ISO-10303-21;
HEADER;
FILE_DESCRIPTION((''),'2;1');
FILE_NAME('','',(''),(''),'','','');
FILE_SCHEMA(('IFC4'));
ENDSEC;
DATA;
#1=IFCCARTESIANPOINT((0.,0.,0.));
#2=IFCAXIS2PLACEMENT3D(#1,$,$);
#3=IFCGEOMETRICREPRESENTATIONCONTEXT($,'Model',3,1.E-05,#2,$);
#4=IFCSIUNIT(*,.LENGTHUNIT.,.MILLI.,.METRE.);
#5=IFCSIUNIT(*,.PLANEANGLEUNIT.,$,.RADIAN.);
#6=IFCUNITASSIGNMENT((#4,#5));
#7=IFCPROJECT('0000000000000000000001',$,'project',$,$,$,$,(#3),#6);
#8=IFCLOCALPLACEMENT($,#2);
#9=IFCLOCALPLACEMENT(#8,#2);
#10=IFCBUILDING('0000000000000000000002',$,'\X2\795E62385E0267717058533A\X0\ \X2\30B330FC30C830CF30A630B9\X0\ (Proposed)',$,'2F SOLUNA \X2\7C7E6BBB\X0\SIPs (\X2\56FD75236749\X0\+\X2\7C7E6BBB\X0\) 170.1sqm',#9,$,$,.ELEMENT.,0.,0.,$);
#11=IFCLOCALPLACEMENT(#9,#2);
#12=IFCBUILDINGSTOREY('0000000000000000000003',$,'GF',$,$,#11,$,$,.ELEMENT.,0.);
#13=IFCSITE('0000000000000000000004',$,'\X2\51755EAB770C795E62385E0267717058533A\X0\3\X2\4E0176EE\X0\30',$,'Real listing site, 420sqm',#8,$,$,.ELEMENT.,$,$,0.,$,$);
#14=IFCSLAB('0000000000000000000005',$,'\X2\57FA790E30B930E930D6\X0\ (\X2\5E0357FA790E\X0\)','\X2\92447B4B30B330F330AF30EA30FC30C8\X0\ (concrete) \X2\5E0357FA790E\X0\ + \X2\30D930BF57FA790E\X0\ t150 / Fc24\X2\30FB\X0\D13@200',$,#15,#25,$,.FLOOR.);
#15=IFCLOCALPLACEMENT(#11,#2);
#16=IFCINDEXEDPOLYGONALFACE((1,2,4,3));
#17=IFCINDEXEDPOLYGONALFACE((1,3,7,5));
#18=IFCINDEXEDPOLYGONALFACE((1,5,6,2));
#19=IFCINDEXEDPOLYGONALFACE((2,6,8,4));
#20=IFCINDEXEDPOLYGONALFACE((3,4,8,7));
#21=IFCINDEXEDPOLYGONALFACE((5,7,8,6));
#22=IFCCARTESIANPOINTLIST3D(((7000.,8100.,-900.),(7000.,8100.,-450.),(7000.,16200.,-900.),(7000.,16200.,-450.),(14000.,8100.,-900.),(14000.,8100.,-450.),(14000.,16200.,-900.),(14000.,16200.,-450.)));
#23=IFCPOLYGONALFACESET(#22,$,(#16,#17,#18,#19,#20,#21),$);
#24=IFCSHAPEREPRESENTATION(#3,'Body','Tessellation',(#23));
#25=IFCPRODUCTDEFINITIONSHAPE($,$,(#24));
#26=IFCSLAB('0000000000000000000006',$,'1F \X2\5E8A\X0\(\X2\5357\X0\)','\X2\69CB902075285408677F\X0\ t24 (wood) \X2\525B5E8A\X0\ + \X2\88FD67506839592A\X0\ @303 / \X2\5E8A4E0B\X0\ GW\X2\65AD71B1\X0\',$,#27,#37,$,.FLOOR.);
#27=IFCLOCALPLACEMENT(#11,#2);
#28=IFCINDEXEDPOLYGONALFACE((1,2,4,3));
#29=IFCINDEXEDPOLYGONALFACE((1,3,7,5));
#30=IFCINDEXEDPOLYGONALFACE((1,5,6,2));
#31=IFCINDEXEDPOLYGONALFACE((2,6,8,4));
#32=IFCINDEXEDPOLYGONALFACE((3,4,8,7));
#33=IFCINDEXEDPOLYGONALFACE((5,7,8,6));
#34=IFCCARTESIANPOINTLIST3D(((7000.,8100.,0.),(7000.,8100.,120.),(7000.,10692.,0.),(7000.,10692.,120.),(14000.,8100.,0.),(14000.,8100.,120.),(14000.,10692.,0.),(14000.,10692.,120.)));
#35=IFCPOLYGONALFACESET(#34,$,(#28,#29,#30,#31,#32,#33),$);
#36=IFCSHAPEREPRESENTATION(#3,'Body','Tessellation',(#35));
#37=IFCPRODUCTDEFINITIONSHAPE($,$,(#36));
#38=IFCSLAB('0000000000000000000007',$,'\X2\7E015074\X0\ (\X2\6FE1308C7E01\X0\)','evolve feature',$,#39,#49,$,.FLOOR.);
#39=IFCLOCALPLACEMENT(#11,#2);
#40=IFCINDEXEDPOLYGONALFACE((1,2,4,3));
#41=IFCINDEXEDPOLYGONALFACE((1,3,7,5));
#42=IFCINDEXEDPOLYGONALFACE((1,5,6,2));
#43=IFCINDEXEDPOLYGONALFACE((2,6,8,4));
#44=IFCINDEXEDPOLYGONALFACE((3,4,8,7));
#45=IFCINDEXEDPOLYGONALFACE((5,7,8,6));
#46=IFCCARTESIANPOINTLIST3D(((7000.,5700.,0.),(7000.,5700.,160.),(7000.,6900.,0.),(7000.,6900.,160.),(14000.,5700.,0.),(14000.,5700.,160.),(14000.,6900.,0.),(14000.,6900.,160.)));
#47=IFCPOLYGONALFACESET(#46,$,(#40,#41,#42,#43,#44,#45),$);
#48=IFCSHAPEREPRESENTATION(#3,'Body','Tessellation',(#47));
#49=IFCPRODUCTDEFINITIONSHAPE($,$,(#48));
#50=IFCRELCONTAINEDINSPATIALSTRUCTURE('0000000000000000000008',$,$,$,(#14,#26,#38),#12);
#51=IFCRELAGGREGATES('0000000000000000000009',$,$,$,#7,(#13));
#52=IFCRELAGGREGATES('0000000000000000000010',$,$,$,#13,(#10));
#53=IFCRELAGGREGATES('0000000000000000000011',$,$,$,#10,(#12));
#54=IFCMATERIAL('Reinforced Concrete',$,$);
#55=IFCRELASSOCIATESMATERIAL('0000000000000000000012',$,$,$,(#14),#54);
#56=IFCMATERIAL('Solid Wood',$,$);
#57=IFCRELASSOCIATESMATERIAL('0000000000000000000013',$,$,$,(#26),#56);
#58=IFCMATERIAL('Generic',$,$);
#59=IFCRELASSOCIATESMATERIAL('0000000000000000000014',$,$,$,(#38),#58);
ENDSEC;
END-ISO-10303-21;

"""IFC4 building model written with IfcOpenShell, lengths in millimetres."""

from ifc_helpers import new_model, si_unit, frame, frame_2d, origin, place, context, project, spatial, rectangle, extrude, material, element, save


model = new_model("IFC4")

# Units and contexts
model_context = context("Model", 3, precision=1e-05, world=origin())
ifc_project = project(units=[si_unit("LENGTHUNIT", "METRE", prefix="MILLI"), si_unit("PLANEANGLEUNIT", "RADIAN")], contexts=[model_context])

# Site, building, storey
site_placement = place(None, origin())
site = spatial("IfcSite", under=ifc_project, at=site_placement, Name="兵庫県神戸市東灘区3丁目30", ObjectType="Real listing site, 420sqm", CompositionType="ELEMENT", RefElevation=0.0)
building_placement = place(site_placement, origin())
building = spatial("IfcBuilding", under=site, at=building_placement, Name="神戸市東灘区 コートハウス (Proposed)", ObjectType="2F SOLUNA 籾殻SIPs (国産杉+籾殻) 170.1sqm", CompositionType="ELEMENT", ElevationOfRefHeight=0.0, ElevationOfTerrain=0.0)
storey_placement = place(building_placement, origin())
storey = spatial("IfcBuildingStorey", under=building, at=storey_placement, Name="GF", CompositionType="ELEMENT", Elevation=0.0)

# Slabs
ifc_material_1 = material(Name="Reinforced Concrete")
slab_1_placement = place(storey_placement, frame((3500.0, 4050.0, -450.0)))
element("IfcSlab", 1, at=slab_1_placement, inside=storey, material=ifc_material_1, Name="基礎スラブ (布基礎)", Description="鉄筋コンクリート (concrete) 布基礎 + ベタ基礎 t150 / Fc24・D13@200", PredefinedType="FLOOR", context=model_context, shape_type="SweptSolid", body=[
    extrude(rectangle(XDim=7000.0, YDim=8100.0, at=frame_2d((3500.0, 4050.0))), frame((3500.0, 4050.0, -450.0)), (0.0, 0.0, 1.0), 450.0),
])
ifc_material_2 = material(Name="Solid Wood")
slab_2_placement = place(storey_placement, frame((3500.0, 4050.0, 0.0)))
element("IfcSlab", 2, at=slab_2_placement, inside=storey, material=ifc_material_2, Name="1F 床(南)", Description="構造用合板 t24 (wood) 剛床 + 製材根太 @303 / 床下 GW断熱", PredefinedType="FLOOR", context=model_context, shape_type="SweptSolid", body=[
    extrude(rectangle(XDim=7000.0, YDim=2592.0, at=frame_2d((3500.0, 1296.0))), frame((3500.0, 4050.0, 0.0)), (0.0, 0.0, 1.0), 120.0),
])
ifc_material_3 = material(Name="Generic")
slab_3_placement = place(storey_placement, frame((3500.0, 2850.0, 0.0)))
element("IfcSlab", 3, at=slab_3_placement, inside=storey, material=ifc_material_3, Name="縁側 (濡れ縁)", Description="evolve feature", PredefinedType="FLOOR", context=model_context, shape_type="SweptSolid", body=[
    extrude(rectangle(XDim=7000.0, YDim=1200.0, at=frame_2d((3500.0, 600.0))), frame((3500.0, 2850.0, 0.0)), (0.0, 0.0, 1.0), 160.0),
])

save(model, "model.ifc")
